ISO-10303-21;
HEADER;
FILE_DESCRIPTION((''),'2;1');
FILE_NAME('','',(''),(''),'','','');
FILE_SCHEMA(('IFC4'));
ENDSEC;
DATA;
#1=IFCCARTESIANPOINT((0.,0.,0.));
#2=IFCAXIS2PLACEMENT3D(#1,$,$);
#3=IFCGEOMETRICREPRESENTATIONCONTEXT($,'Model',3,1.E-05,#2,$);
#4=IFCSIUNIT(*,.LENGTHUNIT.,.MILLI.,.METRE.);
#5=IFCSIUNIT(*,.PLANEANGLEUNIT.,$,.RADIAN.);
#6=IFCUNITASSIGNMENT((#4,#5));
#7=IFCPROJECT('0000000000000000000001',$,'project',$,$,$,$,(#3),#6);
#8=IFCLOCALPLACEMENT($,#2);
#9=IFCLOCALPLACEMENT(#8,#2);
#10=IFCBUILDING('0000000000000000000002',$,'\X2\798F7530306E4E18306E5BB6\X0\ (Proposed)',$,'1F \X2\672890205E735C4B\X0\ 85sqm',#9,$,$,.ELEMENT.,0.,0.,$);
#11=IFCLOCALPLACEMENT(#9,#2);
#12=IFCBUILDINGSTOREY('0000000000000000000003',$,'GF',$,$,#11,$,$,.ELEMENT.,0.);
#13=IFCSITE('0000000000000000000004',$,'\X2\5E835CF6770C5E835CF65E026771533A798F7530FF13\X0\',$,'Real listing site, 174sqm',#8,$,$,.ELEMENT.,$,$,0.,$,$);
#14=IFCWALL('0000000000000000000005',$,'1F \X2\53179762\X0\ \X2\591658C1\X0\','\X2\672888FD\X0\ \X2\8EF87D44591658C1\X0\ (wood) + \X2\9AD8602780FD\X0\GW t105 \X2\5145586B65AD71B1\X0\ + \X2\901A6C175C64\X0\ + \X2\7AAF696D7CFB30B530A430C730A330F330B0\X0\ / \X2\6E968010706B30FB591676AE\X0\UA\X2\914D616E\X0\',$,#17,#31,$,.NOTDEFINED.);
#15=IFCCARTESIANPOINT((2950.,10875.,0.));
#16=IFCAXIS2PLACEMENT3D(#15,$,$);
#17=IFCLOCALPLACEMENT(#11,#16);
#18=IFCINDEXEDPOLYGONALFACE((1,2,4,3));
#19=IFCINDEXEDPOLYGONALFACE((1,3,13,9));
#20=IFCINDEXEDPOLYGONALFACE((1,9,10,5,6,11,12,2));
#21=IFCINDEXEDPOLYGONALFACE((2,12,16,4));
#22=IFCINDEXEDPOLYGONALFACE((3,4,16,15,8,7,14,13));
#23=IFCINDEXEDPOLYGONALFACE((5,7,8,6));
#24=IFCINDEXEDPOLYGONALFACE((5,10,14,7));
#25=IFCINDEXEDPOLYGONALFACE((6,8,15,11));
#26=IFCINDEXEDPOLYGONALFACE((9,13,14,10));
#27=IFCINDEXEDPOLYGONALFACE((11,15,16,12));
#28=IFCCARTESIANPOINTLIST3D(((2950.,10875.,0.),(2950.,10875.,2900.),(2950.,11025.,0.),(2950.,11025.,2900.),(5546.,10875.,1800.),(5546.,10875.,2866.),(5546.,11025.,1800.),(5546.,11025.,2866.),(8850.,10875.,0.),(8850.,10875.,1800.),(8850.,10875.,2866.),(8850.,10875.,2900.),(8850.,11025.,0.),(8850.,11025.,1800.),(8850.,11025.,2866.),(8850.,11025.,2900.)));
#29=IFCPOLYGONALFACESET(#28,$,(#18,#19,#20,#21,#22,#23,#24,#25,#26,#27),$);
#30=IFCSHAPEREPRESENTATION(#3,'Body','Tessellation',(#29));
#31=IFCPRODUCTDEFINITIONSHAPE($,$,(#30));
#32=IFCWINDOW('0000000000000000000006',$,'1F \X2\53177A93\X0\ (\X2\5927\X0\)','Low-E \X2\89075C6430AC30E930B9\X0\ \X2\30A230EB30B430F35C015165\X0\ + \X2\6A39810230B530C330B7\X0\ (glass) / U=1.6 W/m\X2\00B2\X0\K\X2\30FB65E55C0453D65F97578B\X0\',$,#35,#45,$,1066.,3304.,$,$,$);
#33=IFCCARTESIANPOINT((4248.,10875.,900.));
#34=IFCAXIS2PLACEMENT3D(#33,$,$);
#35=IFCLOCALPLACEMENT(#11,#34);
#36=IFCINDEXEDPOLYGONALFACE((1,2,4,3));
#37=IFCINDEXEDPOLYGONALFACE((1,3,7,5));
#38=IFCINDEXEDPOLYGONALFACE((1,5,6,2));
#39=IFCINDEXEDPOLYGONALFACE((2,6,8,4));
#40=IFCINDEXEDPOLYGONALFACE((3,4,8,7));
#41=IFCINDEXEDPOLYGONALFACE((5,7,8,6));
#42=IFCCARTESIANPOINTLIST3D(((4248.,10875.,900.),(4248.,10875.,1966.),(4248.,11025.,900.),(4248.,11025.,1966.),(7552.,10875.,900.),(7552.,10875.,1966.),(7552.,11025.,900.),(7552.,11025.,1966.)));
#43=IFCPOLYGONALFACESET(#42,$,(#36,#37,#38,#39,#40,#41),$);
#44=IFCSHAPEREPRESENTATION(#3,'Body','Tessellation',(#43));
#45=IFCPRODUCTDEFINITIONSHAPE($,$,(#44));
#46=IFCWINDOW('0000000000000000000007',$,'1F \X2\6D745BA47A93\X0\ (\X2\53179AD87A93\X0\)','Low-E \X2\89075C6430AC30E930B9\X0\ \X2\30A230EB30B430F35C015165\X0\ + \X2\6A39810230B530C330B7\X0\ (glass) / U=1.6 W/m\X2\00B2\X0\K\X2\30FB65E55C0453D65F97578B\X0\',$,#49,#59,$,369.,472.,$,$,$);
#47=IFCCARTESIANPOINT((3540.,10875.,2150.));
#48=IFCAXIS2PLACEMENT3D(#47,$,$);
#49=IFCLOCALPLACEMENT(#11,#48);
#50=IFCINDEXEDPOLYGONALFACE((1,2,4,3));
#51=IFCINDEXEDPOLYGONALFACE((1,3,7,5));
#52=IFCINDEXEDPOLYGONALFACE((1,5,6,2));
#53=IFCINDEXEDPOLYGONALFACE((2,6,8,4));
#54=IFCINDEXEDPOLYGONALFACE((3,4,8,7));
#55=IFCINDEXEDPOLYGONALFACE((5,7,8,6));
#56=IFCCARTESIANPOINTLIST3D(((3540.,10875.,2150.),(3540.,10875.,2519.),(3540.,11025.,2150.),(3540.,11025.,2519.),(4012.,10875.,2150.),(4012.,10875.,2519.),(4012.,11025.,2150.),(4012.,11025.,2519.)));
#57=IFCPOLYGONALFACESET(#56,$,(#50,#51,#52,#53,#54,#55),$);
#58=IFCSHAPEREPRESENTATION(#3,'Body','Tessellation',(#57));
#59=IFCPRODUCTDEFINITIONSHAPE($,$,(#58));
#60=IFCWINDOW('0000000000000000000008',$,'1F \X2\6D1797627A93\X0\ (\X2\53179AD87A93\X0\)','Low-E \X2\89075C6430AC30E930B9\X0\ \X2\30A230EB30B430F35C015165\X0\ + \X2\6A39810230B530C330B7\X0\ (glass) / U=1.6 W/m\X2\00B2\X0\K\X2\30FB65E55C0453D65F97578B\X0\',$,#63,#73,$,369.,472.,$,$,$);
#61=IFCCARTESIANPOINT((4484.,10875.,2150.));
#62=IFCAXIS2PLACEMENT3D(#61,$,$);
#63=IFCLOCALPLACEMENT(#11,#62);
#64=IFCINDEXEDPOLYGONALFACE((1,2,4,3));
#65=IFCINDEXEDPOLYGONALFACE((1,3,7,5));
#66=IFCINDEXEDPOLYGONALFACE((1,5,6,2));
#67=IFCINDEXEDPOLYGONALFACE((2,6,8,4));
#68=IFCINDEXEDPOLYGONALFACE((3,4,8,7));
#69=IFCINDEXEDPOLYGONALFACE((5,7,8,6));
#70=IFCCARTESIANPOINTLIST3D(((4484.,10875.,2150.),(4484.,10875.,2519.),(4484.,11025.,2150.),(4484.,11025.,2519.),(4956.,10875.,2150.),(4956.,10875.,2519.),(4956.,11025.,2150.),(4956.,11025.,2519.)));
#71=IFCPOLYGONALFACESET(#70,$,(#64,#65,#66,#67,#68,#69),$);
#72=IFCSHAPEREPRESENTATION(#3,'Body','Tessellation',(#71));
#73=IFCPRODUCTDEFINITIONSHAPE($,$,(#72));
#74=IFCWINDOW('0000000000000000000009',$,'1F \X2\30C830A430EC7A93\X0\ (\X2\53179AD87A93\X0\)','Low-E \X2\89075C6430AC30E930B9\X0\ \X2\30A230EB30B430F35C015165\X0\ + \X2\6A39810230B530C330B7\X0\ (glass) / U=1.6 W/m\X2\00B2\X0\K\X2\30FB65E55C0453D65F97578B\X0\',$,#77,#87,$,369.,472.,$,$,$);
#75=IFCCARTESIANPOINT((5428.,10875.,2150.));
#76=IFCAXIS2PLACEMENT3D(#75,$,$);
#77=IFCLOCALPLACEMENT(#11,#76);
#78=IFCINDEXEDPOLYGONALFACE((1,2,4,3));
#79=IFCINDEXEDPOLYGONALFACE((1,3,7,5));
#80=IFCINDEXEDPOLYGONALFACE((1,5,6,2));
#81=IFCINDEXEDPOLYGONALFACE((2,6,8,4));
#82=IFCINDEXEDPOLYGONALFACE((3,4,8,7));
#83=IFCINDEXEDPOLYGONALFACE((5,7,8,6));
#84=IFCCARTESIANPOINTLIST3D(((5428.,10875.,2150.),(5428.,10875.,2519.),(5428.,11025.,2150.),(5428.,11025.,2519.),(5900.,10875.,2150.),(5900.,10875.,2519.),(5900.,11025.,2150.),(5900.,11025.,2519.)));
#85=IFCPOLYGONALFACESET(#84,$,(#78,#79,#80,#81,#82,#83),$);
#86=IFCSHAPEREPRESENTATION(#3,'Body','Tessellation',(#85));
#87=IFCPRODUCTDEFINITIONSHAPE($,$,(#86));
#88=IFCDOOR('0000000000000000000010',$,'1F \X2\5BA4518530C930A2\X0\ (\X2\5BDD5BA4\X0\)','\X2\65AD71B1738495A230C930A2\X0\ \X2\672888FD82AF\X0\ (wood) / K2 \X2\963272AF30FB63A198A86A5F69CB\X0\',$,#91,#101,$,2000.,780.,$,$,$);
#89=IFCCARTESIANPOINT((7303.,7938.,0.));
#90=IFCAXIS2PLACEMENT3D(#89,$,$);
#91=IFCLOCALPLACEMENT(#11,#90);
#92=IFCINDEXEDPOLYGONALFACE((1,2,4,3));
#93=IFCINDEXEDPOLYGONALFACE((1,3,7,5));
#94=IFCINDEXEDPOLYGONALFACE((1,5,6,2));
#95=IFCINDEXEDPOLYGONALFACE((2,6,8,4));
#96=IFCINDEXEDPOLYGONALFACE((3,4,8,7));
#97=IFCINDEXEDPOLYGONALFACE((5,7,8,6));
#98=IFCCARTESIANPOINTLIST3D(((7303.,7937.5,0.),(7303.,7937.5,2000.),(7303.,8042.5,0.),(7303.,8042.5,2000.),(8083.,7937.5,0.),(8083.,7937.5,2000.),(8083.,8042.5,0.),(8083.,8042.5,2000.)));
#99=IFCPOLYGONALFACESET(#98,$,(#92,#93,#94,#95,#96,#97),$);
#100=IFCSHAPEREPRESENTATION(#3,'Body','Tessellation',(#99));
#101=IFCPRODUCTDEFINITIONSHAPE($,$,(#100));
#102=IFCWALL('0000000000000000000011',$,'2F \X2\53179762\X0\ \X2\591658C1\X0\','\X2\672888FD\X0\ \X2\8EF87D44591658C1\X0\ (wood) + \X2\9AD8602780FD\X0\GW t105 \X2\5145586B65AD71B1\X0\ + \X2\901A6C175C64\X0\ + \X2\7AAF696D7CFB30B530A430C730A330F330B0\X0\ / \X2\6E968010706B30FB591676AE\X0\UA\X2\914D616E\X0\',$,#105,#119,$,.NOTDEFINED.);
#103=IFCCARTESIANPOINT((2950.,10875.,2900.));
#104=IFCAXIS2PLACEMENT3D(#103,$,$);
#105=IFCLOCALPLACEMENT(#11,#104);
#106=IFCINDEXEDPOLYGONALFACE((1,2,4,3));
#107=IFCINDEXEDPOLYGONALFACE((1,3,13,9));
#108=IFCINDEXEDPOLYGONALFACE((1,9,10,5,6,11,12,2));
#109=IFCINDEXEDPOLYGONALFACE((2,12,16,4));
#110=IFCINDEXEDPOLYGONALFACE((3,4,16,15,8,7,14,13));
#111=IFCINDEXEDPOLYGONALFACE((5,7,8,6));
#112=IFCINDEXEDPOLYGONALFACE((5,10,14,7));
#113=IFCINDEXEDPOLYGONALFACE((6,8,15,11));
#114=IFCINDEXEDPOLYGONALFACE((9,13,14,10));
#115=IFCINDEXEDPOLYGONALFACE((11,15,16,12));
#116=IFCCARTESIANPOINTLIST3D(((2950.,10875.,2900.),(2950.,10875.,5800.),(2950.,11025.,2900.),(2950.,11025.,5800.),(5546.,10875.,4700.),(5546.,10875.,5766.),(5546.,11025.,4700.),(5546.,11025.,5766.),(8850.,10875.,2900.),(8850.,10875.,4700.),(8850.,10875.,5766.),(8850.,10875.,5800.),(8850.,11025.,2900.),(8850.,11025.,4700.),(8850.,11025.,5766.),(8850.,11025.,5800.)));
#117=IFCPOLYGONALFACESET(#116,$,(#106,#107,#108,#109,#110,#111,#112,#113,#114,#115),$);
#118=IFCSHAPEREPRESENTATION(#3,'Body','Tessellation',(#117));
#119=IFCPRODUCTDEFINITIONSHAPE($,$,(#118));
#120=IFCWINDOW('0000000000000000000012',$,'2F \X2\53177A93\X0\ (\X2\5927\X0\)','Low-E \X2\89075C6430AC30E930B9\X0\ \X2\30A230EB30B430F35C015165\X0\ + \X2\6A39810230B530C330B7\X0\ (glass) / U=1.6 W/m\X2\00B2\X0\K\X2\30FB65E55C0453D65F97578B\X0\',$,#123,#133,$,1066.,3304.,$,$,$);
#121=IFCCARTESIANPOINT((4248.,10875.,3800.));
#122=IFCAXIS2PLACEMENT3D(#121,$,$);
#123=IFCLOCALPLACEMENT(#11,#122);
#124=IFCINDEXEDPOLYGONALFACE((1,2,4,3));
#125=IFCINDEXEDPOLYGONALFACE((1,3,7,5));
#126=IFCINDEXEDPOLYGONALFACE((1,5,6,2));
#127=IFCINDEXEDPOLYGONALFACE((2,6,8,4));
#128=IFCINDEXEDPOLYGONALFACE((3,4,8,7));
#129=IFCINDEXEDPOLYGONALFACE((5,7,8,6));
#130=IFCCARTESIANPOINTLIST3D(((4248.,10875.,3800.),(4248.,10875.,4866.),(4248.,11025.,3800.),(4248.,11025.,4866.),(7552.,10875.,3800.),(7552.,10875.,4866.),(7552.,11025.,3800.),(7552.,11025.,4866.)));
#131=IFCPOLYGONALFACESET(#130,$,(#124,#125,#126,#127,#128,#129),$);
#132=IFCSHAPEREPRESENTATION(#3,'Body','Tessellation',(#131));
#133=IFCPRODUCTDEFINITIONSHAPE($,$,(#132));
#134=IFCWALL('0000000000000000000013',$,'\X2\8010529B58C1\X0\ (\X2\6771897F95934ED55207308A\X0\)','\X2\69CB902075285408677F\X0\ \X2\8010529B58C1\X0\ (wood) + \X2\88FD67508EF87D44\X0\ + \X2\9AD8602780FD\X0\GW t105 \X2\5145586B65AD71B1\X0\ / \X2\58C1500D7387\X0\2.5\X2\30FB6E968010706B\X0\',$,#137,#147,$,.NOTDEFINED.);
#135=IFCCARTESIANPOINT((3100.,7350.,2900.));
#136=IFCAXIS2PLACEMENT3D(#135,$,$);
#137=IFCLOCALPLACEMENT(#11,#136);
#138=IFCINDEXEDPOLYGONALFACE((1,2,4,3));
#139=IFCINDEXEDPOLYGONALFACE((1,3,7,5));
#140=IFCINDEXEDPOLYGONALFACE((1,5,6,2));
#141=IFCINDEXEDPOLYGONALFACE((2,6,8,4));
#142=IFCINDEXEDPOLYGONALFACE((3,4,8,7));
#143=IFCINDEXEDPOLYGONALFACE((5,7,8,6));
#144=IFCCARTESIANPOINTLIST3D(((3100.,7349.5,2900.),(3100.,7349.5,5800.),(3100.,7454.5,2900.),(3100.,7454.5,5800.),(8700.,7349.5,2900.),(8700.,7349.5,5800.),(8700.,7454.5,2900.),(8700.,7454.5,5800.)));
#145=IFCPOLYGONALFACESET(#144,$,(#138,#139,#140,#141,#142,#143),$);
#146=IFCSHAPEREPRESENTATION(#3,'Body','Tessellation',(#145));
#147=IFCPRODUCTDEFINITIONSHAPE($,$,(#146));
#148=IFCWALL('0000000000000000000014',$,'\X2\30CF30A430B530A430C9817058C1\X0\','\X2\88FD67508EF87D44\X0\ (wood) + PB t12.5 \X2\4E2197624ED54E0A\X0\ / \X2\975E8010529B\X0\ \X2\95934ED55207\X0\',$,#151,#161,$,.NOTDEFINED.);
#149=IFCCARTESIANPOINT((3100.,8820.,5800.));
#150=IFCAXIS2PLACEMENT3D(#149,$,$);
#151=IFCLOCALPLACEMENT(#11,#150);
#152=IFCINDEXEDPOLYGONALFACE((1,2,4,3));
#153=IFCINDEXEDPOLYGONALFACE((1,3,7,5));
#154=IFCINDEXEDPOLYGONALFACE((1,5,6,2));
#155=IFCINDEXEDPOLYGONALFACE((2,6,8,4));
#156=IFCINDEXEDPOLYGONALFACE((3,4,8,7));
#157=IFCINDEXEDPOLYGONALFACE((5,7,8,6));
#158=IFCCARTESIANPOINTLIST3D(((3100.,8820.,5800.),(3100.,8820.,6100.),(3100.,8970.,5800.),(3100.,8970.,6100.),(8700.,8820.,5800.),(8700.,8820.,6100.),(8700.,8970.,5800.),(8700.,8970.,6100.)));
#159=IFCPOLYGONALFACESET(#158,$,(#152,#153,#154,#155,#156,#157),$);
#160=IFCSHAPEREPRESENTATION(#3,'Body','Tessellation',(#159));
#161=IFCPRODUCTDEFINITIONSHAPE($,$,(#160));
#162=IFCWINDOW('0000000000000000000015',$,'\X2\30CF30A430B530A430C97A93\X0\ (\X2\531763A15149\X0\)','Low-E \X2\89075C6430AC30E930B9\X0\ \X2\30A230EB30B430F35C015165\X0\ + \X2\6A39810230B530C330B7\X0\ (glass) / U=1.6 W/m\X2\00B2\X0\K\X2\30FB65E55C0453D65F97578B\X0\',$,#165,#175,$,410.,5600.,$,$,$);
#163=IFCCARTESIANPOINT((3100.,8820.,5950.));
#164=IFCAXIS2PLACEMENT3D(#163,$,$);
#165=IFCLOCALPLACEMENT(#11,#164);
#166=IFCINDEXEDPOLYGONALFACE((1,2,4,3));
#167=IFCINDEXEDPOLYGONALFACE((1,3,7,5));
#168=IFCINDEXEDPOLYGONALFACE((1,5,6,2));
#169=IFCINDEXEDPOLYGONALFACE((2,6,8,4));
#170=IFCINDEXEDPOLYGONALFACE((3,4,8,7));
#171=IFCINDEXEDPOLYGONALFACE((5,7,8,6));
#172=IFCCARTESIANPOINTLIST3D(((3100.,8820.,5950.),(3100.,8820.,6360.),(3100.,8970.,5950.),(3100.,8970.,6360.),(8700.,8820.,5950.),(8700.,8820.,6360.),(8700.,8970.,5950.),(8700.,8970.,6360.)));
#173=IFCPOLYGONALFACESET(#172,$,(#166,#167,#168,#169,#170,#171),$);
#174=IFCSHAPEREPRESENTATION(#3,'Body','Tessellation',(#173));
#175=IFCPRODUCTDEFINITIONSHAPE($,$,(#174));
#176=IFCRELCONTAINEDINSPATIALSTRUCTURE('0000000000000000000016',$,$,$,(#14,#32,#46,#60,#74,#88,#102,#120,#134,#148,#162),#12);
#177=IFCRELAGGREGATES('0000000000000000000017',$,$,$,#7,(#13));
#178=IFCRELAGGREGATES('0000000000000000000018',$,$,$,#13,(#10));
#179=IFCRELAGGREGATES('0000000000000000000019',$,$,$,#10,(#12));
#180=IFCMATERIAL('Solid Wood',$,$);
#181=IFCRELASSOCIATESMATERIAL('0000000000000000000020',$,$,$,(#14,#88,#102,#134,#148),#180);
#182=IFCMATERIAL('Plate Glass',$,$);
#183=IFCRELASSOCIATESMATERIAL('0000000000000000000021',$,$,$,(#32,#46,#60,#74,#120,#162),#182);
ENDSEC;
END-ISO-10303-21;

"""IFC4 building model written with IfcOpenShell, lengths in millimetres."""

from ifc_helpers import new_model, si_unit, frame, frame_2d, origin, place, context, project, spatial, rectangle, extrude, material, element, fill, save


model = new_model("IFC4")

# Units and contexts
model_context = context("Model", 3, precision=1e-05, world=origin())
ifc_project = project(units=[si_unit("LENGTHUNIT", "METRE", prefix="MILLI"), si_unit("PLANEANGLEUNIT", "RADIAN")], contexts=[model_context])

# Site, building, storey
site_placement = place(None, origin())
site = spatial("IfcSite", under=ifc_project, at=site_placement, Name="広島県広島市東区福田３", ObjectType="Real listing site, 174sqm", CompositionType="ELEMENT", RefElevation=0.0)
building_placement = place(site_placement, origin())
building = spatial("IfcBuilding", under=site, at=building_placement, Name="福田の丘の家 (Proposed)", ObjectType="1F 木造平屋 85sqm", CompositionType="ELEMENT", ElevationOfRefHeight=0.0, ElevationOfTerrain=0.0)
storey_placement = place(building_placement, origin())
storey = spatial("IfcBuildingStorey", under=building, at=storey_placement, Name="GF", CompositionType="ELEMENT", Elevation=0.0)

# Wall, openings, windows
ifc_material_1 = material(Name="Solid Wood")
wall_1_placement = place(storey_placement, frame((2950.0, 10875.0, 0.0)))
wall_1 = element("IfcWall", 1, at=wall_1_placement, inside=storey, material=ifc_material_1, Name="1F 北面 外壁", Description="木製 軸組外壁 (wood) + 高性能GW t105 充填断熱 + 通気層 + 窯業系サイディング / 準耐火・外皮UA配慮", PredefinedType="NOTDEFINED", context=model_context, shape_type="SweptSolid", body=[
    extrude(rectangle(XDim=5900.0, YDim=150.0, at=frame_2d((2950.0, 75.0))), frame((2950.0, 10875.0, 0.0)), (0.0, 0.0, 1.0), 2900.0),
])
opening_1_placement = place(storey_placement, frame((4248.0, 10875.0, 900.0)))
opening_1 = element("IfcOpeningElement", 2, at=opening_1_placement, cuts=wall_1, PredefinedType="NOTDEFINED", context=model_context, shape_type="SweptSolid", body=[
    extrude(rectangle(XDim=3304.0, YDim=150.0, at=frame_2d((1652.0, 75.0))), frame((4248.0, 10875.0, 900.0)), (0.0, 0.0, 1.0), 1066.0),
])
opening_2_placement = place(storey_placement, frame((3540.0, 10875.0, 2150.0)))
opening_2 = element("IfcOpeningElement", 3, at=opening_2_placement, cuts=wall_1, PredefinedType="NOTDEFINED", context=model_context, shape_type="SweptSolid", body=[
    extrude(rectangle(XDim=472.0, YDim=150.0, at=frame_2d((236.0, 75.0))), frame((3540.0, 10875.0, 2150.0)), (0.0, 0.0, 1.0), 369.0),
])
opening_3_placement = place(storey_placement, frame((4484.0, 10875.0, 2150.0)))
opening_3 = element("IfcOpeningElement", 4, at=opening_3_placement, cuts=wall_1, PredefinedType="NOTDEFINED", context=model_context, shape_type="SweptSolid", body=[
    extrude(rectangle(XDim=472.0, YDim=150.0, at=frame_2d((236.0, 75.0))), frame((4484.0, 10875.0, 2150.0)), (0.0, 0.0, 1.0), 369.0),
])
opening_4_placement = place(storey_placement, frame((5428.0, 10875.0, 2150.0)))
opening_4 = element("IfcOpeningElement", 5, at=opening_4_placement, cuts=wall_1, PredefinedType="NOTDEFINED", context=model_context, shape_type="SweptSolid", body=[
    extrude(rectangle(XDim=472.0, YDim=150.0, at=frame_2d((236.0, 75.0))), frame((5428.0, 10875.0, 2150.0)), (0.0, 0.0, 1.0), 369.0),
])
ifc_material_2 = material(Name="Plate Glass")
window_1_placement = place(storey_placement, frame((4248.0, 10875.0, 900.0)))
window_1 = element("IfcWindow", 6, at=window_1_placement, inside=storey, material=ifc_material_2, Name="1F 北窓 (大)", Description="Low-E 複層ガラス アルゴン封入 + 樹脂サッシ (glass) / U=1.6 W/m²K・日射取得型", OverallHeight=1066.0, OverallWidth=3304.0, context=model_context, shape_type="SweptSolid", body=[
    extrude(rectangle(XDim=3304.0, YDim=150.0, at=frame_2d((1652.0, 75.0))), frame((4248.0, 10875.0, 900.0)), (0.0, 0.0, 1.0), 1066.0),
])
fill(opening_1, window_1)
window_2_placement = place(storey_placement, frame((3540.0, 10875.0, 2150.0)))
window_2 = element("IfcWindow", 7, at=window_2_placement, inside=storey, material=ifc_material_2, Name="1F 浴室窓 (北高窓)", Description="Low-E 複層ガラス アルゴン封入 + 樹脂サッシ (glass) / U=1.6 W/m²K・日射取得型", OverallHeight=369.0, OverallWidth=472.0, context=model_context, shape_type="SweptSolid", body=[
    extrude(rectangle(XDim=472.0, YDim=150.0, at=frame_2d((236.0, 75.0))), frame((3540.0, 10875.0, 2150.0)), (0.0, 0.0, 1.0), 369.0),
])
fill(opening_2, window_2)
window_3_placement = place(storey_placement, frame((4484.0, 10875.0, 2150.0)))
window_3 = element("IfcWindow", 8, at=window_3_placement, inside=storey, material=ifc_material_2, Name="1F 洗面窓 (北高窓)", Description="Low-E 複層ガラス アルゴン封入 + 樹脂サッシ (glass) / U=1.6 W/m²K・日射取得型", OverallHeight=369.0, OverallWidth=472.0, context=model_context, shape_type="SweptSolid", body=[
    extrude(rectangle(XDim=472.0, YDim=150.0, at=frame_2d((236.0, 75.0))), frame((4484.0, 10875.0, 2150.0)), (0.0, 0.0, 1.0), 369.0),
])
fill(opening_3, window_3)
window_4_placement = place(storey_placement, frame((5428.0, 10875.0, 2150.0)))
window_4 = element("IfcWindow", 9, at=window_4_placement, inside=storey, material=ifc_material_2, Name="1F トイレ窓 (北高窓)", Description="Low-E 複層ガラス アルゴン封入 + 樹脂サッシ (glass) / U=1.6 W/m²K・日射取得型", OverallHeight=369.0, OverallWidth=472.0, context=model_context, shape_type="SweptSolid", body=[
    extrude(rectangle(XDim=472.0, YDim=150.0, at=frame_2d((236.0, 75.0))), frame((5428.0, 10875.0, 2150.0)), (0.0, 0.0, 1.0), 369.0),
])
fill(opening_4, window_4)

# Door
door_1_placement = place(storey_placement, frame((7303.0, 7938.0, 0.0)))
element("IfcDoor", 10, at=door_1_placement, inside=storey, material=ifc_material_1, Name="1F 室内ドア (寝室)", Description="断熱玄関ドア 木製芯 (wood) / K2 防犯・採風機構", OverallHeight=2000.0, OverallWidth=780.0, context=model_context, shape_type="SweptSolid", body=[
    extrude(rectangle(XDim=780.0, YDim=105.0, at=frame_2d((390.0, 52.0))), frame((7303.0, 7938.0, 0.0)), (0.0, 0.0, 1.0), 2000.0),
])

# Wall, opening, window
wall_2_placement = place(storey_placement, frame((2950.0, 10875.0, 2900.0)))
wall_2 = element("IfcWall", 11, at=wall_2_placement, inside=storey, material=ifc_material_1, Name="2F 北面 外壁", Description="木製 軸組外壁 (wood) + 高性能GW t105 充填断熱 + 通気層 + 窯業系サイディング / 準耐火・外皮UA配慮", PredefinedType="NOTDEFINED", context=model_context, shape_type="SweptSolid", body=[
    extrude(rectangle(XDim=5900.0, YDim=150.0, at=frame_2d((2950.0, 75.0))), frame((2950.0, 10875.0, 2900.0)), (0.0, 0.0, 1.0), 2900.0),
])
opening_5_placement = place(storey_placement, frame((4248.0, 10875.0, 3800.0)))
opening_5 = element("IfcOpeningElement", 12, at=opening_5_placement, cuts=wall_2, PredefinedType="NOTDEFINED", context=model_context, shape_type="SweptSolid", body=[
    extrude(rectangle(XDim=3304.0, YDim=150.0, at=frame_2d((1652.0, 75.0))), frame((4248.0, 10875.0, 3800.0)), (0.0, 0.0, 1.0), 1066.0),
])
window_5_placement = place(storey_placement, frame((4248.0, 10875.0, 3800.0)))
window_5 = element("IfcWindow", 13, at=window_5_placement, inside=storey, material=ifc_material_2, Name="2F 北窓 (大)", Description="Low-E 複層ガラス アルゴン封入 + 樹脂サッシ (glass) / U=1.6 W/m²K・日射取得型", OverallHeight=1066.0, OverallWidth=3304.0, context=model_context, shape_type="SweptSolid", body=[
    extrude(rectangle(XDim=3304.0, YDim=150.0, at=frame_2d((1652.0, 75.0))), frame((4248.0, 10875.0, 3800.0)), (0.0, 0.0, 1.0), 1066.0),
])
fill(opening_5, window_5)

# Wall
wall_3_placement = place(storey_placement, frame((3100.0, 7350.0, 2900.0)))
element("IfcWall", 14, at=wall_3_placement, inside=storey, material=ifc_material_1, Name="耐力壁 (東西間仕切り)", Description="構造用合板 耐力壁 (wood) + 製材軸組 + 高性能GW t105 充填断熱 / 壁倍率2.5・準耐火", PredefinedType="NOTDEFINED", context=model_context, shape_type="SweptSolid", body=[
    extrude(rectangle(XDim=5600.0, YDim=105.0, at=frame_2d((2800.0, 52.0))), frame((3100.0, 7350.0, 2900.0)), (0.0, 0.0, 1.0), 2900.0),
])

# Wall, opening, window
wall_4_placement = place(storey_placement, frame((3100.0, 8820.0, 5800.0)))
wall_4 = element("IfcWall", 15, at=wall_4_placement, inside=storey, material=ifc_material_1, Name="ハイサイド腰壁", Description="製材軸組 (wood) + PB t12.5 両面仕上 / 非耐力 間仕切", PredefinedType="NOTDEFINED", context=model_context, shape_type="SweptSolid", body=[
    extrude(rectangle(XDim=5600.0, YDim=150.0, at=frame_2d((2800.0, 75.0))), frame((3100.0, 8820.0, 5800.0)), (0.0, 0.0, 1.0), 700.0),
])
opening_6_placement = place(storey_placement, frame((3100.0, 8820.0, 5950.0)))
opening_6 = element("IfcOpeningElement", 16, at=opening_6_placement, cuts=wall_4, PredefinedType="NOTDEFINED", context=model_context, shape_type="SweptSolid", body=[
    extrude(rectangle(XDim=5600.0, YDim=150.0, at=frame_2d((2800.0, 75.0))), frame((3100.0, 8820.0, 5950.0)), (0.0, 0.0, 1.0), 410.0),
])
window_6_placement = place(storey_placement, frame((3100.0, 8820.0, 5950.0)))
window_6 = element("IfcWindow", 17, at=window_6_placement, inside=storey, material=ifc_material_2, Name="ハイサイド窓 (北採光)", Description="Low-E 複層ガラス アルゴン封入 + 樹脂サッシ (glass) / U=1.6 W/m²K・日射取得型", OverallHeight=410.0, OverallWidth=5600.0, context=model_context, shape_type="SweptSolid", body=[
    extrude(rectangle(XDim=5600.0, YDim=150.0, at=frame_2d((2800.0, 75.0))), frame((3100.0, 8820.0, 5950.0)), (0.0, 0.0, 1.0), 410.0),
])
fill(opening_6, window_6)

save(model, "model.ifc")
